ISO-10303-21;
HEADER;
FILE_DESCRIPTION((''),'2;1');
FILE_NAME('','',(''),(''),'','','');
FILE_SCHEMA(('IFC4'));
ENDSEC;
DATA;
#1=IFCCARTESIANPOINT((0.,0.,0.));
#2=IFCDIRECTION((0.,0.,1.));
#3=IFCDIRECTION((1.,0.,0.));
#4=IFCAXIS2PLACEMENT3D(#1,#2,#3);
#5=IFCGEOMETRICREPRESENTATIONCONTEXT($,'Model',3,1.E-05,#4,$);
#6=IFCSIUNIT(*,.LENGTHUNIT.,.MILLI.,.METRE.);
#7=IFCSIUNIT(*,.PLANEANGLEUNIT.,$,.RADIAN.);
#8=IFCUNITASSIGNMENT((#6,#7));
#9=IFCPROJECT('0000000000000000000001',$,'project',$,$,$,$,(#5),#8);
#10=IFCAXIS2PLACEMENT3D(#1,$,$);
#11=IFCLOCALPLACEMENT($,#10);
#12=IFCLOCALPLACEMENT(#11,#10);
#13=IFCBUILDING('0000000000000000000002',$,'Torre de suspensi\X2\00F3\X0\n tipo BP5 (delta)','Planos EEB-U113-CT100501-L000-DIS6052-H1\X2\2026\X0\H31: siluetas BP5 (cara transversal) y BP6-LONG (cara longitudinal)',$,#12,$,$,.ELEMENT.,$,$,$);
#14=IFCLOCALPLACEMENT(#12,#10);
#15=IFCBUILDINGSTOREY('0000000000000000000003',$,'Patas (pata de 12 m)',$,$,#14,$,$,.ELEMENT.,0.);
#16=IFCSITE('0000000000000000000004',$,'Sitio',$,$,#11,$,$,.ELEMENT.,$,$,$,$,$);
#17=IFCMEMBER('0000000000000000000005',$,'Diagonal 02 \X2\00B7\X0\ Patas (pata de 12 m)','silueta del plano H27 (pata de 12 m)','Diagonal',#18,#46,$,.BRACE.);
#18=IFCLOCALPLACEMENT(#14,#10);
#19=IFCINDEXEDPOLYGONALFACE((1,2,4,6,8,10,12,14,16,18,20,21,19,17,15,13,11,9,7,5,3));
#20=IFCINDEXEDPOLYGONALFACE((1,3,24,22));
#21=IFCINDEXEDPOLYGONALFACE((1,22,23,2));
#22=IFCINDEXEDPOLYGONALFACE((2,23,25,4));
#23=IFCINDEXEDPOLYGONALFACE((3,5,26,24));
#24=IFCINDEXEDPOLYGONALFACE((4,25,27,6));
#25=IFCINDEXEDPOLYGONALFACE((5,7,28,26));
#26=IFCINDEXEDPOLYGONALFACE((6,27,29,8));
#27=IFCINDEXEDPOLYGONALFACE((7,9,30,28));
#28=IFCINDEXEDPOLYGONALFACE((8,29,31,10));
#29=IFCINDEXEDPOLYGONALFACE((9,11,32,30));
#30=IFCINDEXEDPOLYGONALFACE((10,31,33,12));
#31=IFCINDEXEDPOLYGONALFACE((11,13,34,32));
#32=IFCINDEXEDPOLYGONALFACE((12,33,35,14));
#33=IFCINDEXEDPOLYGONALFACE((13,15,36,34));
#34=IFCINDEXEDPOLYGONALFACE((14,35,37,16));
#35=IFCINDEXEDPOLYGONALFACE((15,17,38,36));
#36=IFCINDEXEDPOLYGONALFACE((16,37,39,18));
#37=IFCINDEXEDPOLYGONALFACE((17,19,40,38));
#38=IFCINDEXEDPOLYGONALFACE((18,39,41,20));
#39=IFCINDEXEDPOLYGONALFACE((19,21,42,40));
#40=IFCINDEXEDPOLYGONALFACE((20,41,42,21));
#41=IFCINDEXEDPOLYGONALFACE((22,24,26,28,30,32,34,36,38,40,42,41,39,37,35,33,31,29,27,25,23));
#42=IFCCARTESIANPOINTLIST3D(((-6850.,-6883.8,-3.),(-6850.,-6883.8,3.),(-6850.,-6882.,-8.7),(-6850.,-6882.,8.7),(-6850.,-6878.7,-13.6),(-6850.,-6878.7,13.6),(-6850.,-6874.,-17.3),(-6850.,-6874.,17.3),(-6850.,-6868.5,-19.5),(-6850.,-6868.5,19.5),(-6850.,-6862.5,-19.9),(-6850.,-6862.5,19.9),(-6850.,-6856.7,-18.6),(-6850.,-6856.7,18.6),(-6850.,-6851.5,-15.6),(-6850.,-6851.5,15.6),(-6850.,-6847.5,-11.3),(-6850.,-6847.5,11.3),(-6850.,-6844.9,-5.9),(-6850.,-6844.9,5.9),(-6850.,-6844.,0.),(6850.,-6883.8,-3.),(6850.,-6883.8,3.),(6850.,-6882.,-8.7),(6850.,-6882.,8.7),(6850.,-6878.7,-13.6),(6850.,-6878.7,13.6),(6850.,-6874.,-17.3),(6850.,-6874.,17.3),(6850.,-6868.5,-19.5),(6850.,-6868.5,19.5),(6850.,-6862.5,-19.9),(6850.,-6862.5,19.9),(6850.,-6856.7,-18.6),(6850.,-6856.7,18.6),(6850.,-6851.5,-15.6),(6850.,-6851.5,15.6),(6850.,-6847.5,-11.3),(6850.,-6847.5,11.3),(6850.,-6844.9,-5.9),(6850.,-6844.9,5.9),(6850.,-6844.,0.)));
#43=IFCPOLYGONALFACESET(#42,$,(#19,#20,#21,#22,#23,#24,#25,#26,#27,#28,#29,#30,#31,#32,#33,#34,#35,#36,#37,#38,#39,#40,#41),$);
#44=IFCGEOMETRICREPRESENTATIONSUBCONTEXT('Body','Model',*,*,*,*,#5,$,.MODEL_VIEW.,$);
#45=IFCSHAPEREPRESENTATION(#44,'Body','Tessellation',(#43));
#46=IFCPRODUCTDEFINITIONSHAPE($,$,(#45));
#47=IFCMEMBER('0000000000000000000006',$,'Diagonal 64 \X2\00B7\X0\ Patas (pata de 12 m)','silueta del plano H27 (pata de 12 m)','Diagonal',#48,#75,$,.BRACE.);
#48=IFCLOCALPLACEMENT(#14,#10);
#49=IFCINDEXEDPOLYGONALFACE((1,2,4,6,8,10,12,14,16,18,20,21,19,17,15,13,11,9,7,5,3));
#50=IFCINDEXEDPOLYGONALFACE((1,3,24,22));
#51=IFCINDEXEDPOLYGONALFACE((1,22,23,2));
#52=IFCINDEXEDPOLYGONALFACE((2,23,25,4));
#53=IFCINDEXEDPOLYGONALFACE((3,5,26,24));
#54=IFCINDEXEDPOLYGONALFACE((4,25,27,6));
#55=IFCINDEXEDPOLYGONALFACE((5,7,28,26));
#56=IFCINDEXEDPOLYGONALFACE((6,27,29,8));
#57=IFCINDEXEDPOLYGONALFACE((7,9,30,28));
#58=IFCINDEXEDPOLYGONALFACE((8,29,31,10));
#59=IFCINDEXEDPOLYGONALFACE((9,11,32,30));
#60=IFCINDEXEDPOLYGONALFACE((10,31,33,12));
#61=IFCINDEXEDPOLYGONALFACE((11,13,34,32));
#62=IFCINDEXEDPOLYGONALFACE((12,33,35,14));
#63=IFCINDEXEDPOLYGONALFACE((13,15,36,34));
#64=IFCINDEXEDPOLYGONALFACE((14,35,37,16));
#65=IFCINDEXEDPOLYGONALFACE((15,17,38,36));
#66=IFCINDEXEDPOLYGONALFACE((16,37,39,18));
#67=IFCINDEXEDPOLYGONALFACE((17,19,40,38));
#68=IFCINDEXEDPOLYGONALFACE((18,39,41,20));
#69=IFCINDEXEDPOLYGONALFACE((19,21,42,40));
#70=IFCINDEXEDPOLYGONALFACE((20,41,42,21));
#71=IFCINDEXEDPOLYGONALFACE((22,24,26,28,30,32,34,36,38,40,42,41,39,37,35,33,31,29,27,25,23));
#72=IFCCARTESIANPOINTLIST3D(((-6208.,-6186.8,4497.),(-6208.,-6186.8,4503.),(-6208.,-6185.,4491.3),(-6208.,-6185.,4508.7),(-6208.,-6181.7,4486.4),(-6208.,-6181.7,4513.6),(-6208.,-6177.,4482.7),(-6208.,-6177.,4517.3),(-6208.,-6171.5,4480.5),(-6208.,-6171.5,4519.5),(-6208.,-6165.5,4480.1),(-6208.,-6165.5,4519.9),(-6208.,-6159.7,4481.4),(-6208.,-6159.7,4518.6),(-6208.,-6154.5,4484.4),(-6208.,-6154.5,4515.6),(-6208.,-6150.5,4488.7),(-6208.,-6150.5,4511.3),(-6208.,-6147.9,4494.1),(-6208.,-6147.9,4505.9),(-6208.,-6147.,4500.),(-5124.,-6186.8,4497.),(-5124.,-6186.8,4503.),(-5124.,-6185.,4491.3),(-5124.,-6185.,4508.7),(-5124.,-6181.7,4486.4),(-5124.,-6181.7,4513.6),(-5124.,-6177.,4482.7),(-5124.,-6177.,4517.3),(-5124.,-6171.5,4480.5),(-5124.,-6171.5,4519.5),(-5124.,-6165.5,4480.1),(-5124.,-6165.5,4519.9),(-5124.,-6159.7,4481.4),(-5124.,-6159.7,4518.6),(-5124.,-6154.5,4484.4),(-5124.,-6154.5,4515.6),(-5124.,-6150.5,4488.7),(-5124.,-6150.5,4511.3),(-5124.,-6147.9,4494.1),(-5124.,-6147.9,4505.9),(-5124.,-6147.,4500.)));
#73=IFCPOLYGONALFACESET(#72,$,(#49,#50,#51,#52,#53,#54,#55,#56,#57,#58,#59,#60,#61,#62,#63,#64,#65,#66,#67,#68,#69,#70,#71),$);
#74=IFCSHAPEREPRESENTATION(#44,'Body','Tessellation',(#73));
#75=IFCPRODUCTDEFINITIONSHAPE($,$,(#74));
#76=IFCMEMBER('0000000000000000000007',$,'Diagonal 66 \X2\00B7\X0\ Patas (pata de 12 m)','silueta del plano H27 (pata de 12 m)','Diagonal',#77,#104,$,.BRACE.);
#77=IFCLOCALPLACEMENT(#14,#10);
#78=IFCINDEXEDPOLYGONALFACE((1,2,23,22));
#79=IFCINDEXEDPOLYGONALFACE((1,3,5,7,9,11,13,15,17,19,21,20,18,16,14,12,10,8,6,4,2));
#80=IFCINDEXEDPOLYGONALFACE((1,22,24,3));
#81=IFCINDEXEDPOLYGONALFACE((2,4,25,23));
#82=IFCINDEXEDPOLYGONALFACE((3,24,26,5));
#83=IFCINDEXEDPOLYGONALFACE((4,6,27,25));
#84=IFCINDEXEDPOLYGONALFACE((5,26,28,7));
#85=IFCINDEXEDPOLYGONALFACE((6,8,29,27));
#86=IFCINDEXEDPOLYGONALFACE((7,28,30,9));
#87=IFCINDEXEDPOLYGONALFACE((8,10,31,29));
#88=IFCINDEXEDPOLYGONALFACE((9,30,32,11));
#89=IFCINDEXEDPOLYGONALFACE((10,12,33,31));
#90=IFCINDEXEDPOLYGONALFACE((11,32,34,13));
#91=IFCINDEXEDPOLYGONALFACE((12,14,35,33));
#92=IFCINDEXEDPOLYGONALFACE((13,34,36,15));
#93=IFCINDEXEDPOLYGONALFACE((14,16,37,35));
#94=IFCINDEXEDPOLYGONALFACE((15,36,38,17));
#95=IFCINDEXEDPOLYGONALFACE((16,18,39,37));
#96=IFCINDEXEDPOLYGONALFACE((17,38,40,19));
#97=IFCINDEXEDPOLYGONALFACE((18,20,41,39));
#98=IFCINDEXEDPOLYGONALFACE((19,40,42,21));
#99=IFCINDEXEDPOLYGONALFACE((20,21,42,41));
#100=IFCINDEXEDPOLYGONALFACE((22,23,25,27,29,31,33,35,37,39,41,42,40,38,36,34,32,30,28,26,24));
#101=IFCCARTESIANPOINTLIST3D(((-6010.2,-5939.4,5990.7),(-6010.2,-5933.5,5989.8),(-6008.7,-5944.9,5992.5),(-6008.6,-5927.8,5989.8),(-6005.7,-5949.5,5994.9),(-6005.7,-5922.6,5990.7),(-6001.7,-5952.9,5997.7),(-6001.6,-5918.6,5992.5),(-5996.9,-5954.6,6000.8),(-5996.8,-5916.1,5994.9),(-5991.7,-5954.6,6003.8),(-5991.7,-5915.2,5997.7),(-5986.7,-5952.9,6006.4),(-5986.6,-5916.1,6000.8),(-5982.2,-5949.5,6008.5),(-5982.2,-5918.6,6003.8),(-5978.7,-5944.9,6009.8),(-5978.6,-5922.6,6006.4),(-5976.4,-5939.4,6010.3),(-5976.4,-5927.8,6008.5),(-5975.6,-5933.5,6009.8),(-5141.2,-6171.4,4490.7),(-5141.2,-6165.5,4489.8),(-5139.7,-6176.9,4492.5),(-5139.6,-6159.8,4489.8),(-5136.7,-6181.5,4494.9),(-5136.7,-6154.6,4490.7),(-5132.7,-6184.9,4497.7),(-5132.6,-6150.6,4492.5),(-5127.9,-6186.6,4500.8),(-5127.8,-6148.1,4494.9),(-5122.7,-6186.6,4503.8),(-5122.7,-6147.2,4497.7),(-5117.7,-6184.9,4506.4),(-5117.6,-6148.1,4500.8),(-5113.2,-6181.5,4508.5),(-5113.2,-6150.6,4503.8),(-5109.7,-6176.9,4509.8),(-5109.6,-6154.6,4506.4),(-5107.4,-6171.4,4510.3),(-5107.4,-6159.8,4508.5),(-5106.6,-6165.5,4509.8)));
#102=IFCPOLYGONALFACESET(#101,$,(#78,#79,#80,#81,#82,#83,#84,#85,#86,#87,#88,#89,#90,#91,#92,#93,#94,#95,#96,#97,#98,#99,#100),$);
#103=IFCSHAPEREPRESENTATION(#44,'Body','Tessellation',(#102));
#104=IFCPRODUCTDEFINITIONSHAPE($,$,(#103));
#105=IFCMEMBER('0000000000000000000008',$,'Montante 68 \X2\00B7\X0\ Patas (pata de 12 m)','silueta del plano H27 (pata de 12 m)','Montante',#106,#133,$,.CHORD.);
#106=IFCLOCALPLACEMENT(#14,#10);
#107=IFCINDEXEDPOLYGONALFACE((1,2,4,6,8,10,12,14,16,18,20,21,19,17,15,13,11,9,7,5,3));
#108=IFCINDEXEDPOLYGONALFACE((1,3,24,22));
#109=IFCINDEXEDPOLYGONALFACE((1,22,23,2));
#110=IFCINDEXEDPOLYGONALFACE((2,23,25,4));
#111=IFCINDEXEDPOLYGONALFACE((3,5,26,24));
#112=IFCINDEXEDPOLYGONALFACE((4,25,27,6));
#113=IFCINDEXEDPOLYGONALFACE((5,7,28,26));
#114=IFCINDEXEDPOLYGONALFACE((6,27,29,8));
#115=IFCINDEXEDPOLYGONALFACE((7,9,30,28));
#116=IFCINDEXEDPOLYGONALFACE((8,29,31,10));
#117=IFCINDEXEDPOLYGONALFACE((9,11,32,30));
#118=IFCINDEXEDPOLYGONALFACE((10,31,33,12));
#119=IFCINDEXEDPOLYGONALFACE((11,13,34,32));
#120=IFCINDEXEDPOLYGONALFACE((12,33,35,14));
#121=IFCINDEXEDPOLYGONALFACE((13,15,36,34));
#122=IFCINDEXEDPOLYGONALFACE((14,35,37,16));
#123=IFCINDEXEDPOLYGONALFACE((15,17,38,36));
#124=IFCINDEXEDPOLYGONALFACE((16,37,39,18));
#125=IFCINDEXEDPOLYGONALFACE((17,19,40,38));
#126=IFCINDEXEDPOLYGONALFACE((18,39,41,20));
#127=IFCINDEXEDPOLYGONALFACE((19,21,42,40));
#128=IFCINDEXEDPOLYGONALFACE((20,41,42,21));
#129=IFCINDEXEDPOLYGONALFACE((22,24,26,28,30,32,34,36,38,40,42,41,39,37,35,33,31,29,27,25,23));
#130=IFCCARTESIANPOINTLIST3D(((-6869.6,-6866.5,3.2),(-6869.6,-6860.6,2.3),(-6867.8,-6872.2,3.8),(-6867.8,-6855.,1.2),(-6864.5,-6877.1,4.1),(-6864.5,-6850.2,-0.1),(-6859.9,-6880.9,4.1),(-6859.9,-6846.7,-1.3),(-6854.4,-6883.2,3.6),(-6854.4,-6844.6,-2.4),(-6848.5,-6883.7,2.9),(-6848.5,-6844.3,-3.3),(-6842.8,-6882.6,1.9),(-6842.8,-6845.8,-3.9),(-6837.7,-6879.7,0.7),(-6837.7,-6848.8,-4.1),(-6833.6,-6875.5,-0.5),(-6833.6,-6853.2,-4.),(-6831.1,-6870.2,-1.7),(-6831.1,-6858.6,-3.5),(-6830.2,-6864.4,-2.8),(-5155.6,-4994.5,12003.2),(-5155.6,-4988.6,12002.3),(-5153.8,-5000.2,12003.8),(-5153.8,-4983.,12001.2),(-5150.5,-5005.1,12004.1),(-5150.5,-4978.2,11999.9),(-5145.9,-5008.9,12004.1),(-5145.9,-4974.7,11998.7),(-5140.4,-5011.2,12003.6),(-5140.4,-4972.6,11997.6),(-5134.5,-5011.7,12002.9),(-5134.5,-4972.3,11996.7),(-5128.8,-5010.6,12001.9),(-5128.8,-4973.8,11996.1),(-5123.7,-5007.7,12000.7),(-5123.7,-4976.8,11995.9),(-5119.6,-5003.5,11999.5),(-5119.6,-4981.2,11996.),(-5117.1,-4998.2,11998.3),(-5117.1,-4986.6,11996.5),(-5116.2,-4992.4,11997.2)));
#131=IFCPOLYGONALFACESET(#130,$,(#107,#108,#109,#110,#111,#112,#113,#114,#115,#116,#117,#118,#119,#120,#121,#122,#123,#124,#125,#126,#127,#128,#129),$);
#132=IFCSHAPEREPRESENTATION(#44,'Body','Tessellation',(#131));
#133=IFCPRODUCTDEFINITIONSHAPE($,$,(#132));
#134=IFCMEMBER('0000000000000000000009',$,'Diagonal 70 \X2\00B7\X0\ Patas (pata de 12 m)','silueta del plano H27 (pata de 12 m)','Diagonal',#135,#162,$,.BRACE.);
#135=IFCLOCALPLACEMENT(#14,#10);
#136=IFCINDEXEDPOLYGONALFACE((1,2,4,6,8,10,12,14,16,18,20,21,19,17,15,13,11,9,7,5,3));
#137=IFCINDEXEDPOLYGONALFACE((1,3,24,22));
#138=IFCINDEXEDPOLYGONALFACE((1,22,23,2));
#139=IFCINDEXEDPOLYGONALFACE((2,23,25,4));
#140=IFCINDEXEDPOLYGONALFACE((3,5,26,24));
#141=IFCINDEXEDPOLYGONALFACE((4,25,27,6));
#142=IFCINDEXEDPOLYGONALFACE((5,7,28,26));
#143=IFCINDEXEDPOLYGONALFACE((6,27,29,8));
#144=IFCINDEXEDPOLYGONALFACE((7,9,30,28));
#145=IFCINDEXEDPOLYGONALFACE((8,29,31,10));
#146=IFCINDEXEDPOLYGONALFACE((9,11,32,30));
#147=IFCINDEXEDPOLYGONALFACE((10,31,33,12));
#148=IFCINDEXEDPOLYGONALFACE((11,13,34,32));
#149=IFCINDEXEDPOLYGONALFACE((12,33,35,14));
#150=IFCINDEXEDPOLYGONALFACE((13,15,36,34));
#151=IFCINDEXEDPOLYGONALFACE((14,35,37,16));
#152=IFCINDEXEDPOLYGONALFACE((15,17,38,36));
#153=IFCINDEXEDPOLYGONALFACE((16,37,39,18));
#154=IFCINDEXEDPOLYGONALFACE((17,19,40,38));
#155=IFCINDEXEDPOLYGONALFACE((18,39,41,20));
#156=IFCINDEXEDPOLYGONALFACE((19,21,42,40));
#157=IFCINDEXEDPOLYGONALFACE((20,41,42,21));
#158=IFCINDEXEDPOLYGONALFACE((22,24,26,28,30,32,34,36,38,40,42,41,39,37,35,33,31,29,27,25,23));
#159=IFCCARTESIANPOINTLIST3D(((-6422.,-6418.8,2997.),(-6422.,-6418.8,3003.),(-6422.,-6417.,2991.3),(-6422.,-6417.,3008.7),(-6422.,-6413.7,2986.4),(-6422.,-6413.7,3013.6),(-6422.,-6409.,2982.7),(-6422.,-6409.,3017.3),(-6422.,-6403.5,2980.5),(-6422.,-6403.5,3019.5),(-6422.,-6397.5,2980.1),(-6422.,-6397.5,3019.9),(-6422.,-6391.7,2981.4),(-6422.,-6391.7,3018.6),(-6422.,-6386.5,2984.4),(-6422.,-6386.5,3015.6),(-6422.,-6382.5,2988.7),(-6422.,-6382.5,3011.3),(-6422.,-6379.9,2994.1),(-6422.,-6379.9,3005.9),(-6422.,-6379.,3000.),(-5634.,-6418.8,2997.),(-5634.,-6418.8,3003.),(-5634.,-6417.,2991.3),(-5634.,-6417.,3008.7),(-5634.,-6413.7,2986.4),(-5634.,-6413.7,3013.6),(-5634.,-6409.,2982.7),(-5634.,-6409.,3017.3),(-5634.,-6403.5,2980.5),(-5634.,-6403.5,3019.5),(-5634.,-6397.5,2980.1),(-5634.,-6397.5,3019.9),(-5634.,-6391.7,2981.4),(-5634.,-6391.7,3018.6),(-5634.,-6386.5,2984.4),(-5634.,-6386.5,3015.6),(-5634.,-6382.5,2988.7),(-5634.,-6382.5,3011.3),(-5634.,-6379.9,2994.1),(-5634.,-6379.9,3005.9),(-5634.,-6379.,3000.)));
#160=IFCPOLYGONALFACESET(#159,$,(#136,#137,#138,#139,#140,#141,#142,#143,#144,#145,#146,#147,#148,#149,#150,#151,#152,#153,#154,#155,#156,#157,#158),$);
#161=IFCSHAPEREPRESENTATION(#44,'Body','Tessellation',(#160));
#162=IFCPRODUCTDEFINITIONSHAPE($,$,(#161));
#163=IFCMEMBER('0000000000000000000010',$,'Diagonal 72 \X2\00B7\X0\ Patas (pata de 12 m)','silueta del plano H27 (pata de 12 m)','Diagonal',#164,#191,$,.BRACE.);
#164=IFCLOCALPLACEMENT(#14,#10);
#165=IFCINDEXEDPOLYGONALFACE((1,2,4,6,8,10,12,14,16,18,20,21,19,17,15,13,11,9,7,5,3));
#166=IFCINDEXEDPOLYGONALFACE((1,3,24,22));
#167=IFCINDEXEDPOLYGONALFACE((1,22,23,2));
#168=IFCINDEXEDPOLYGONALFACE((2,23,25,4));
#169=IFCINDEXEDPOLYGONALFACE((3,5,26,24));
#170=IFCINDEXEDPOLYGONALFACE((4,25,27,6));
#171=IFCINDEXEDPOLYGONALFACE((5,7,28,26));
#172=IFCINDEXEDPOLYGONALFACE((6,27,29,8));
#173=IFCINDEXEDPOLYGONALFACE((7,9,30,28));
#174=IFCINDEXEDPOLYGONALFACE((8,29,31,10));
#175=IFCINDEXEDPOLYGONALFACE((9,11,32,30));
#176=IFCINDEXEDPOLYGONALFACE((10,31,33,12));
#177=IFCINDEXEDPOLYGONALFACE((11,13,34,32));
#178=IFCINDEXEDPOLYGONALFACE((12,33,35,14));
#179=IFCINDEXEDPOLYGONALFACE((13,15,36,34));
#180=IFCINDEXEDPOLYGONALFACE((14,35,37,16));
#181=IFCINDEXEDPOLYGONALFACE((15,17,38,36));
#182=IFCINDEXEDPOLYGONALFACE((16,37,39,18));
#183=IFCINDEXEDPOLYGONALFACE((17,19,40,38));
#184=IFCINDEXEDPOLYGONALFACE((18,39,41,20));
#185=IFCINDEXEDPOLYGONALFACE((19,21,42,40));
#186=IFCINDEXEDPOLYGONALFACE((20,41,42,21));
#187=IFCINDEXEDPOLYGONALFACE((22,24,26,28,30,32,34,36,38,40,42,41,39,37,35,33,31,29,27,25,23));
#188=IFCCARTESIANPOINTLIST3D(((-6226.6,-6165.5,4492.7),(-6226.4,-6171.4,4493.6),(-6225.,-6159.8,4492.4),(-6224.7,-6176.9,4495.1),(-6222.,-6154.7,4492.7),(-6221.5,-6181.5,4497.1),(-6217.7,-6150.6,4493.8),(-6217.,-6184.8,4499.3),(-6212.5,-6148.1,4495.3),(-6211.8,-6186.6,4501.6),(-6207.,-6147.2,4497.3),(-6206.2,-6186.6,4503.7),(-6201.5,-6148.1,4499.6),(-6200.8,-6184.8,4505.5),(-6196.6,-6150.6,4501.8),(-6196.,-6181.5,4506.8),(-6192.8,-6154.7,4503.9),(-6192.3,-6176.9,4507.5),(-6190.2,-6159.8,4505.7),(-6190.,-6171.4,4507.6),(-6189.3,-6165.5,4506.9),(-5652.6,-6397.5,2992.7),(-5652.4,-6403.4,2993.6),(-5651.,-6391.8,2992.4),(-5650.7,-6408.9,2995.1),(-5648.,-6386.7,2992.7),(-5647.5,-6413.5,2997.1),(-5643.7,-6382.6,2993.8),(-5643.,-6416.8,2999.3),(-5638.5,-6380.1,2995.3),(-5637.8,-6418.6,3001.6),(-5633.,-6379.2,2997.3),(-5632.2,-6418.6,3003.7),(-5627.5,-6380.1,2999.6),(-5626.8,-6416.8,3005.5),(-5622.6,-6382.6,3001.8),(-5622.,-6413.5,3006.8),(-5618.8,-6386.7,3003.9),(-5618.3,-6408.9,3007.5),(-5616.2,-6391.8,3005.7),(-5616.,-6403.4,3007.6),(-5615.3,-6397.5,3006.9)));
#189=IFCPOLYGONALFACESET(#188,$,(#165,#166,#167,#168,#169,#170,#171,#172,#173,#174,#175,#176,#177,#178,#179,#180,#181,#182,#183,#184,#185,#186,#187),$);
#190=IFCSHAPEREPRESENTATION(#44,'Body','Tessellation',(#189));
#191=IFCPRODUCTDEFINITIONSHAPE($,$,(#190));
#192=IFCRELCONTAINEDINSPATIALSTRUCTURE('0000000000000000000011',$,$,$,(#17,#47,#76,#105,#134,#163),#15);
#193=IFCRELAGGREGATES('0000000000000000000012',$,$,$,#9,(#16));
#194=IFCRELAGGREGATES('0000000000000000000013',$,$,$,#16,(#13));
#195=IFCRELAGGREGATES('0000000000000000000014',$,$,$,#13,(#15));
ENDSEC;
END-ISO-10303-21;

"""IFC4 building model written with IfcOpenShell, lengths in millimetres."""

from ifc_helpers import new_model, si_unit, frame, origin, origin_with_axes, place, context, subcontext, project, spatial, circle, extrude, element, save


model = new_model("IFC4")

# Units and contexts
model_context = context("Model", 3, precision=1e-05, world=origin_with_axes())
body_context = subcontext(model_context, "Body", "Model", "MODEL_VIEW")
ifc_project = project(units=[si_unit("LENGTHUNIT", "METRE", prefix="MILLI"), si_unit("PLANEANGLEUNIT", "RADIAN")], contexts=[model_context])

# Site, building, storey
site_placement = place(None, origin())
site = spatial("IfcSite", under=ifc_project, at=site_placement, Name="Sitio", CompositionType="ELEMENT")
building_placement = place(site_placement, origin())
building = spatial("IfcBuilding", under=site, at=building_placement, Name="Torre de suspensión tipo BP5 (delta)", Description="Planos EEB-U113-CT100501-L000-DIS6052-H1…H31: siluetas BP5 (cara transversal) y BP6-LONG (cara longitudinal)", CompositionType="ELEMENT")
storey_placement = place(building_placement, origin())
storey = spatial("IfcBuildingStorey", under=building, at=storey_placement, Name="Patas (pata de 12 m)", CompositionType="ELEMENT", Elevation=0.0)

# Members
member_1_placement = place(storey_placement, frame((-6850.0, -6864.0, 0.0), z_axis=(1.0, 0.0, 0.0), x_axis=(0.0, 1.0, 0.0)))
element("IfcMember", 1, at=member_1_placement, inside=storey, Name="Diagonal 02 · Patas (pata de 12 m)", Description="silueta del plano H27 (pata de 12 m)", ObjectType="Diagonal", PredefinedType="BRACE", context=body_context, shape_type="SweptSolid", body=[
    extrude(circle(Radius=20.0), None, (0.0, 0.0, 1.0), 13700.0),
])
member_2_placement = place(storey_placement, frame((-6208.0, -6167.0, 4500.0), z_axis=(1.0, 0.0, 0.0), x_axis=(0.0, 1.0, 0.0)))
element("IfcMember", 2, at=member_2_placement, inside=storey, Name="Diagonal 64 · Patas (pata de 12 m)", Description="silueta del plano H27 (pata de 12 m)", ObjectType="Diagonal", PredefinedType="BRACE", context=body_context, shape_type="SweptSolid", body=[
    extrude(circle(Radius=20.0), None, (0.0, 0.0, 1.0), 1084.0),
])
member_3_placement = place(storey_placement, frame((-5124.0, -6167.0, 4500.0), z_axis=(-0.496857, 0.132648, 0.857635), x_axis=(0.066494, 0.991163, -0.114777)))
element("IfcMember", 3, at=member_3_placement, inside=storey, Name="Diagonal 66 · Patas (pata de 12 m)", Description="silueta del plano H27 (pata de 12 m)", ObjectType="Diagonal", PredefinedType="BRACE", context=body_context, shape_type="SweptSolid", body=[
    extrude(circle(Radius=20.0), None, (0.0, 0.0, 1.0), 1749.0),
])
member_4_placement = place(storey_placement, frame((-6850.0, -6864.0, 0.0), z_axis=(0.139742, 0.152623, 0.978355), x_axis=(0.990188, -0.021539, -0.138072)))
element("IfcMember", 4, at=member_4_placement, inside=storey, Name="Montante 68 · Patas (pata de 12 m)", Description="silueta del plano H27 (pata de 12 m)", ObjectType="Montante", PredefinedType="CHORD", context=body_context, shape_type="SweptSolid", body=[
    extrude(circle(Radius=20.0), None, (0.0, 0.0, 1.0), 12265.5),
])
member_5_placement = place(storey_placement, frame((-6422.0, -6399.0, 3000.0), z_axis=(1.0, 0.0, 0.0), x_axis=(0.0, 1.0, 0.0)))
element("IfcMember", 5, at=member_5_placement, inside=storey, Name="Diagonal 70 · Patas (pata de 12 m)", Description="silueta del plano H27 (pata de 12 m)", ObjectType="Diagonal", PredefinedType="BRACE", context=body_context, shape_type="SweptSolid", body=[
    extrude(circle(Radius=20.0), None, (0.0, 0.0, 1.0), 788.0),
])
member_6_placement = place(storey_placement, frame((-5634.0, -6399.0, 3000.0), z_axis=(-0.353722, 0.142968, 0.92436), x_axis=(0.051096, 0.989727, -0.133525)))
element("IfcMember", 6, at=member_6_placement, inside=storey, Name="Diagonal 72 · Patas (pata de 12 m)", Description="silueta del plano H27 (pata de 12 m)", ObjectType="Diagonal", PredefinedType="BRACE", context=body_context, shape_type="SweptSolid", body=[
    extrude(circle(Radius=20.0), None, (0.0, 0.0, 1.0), 1622.7),
])

save(model, "model.ifc")
